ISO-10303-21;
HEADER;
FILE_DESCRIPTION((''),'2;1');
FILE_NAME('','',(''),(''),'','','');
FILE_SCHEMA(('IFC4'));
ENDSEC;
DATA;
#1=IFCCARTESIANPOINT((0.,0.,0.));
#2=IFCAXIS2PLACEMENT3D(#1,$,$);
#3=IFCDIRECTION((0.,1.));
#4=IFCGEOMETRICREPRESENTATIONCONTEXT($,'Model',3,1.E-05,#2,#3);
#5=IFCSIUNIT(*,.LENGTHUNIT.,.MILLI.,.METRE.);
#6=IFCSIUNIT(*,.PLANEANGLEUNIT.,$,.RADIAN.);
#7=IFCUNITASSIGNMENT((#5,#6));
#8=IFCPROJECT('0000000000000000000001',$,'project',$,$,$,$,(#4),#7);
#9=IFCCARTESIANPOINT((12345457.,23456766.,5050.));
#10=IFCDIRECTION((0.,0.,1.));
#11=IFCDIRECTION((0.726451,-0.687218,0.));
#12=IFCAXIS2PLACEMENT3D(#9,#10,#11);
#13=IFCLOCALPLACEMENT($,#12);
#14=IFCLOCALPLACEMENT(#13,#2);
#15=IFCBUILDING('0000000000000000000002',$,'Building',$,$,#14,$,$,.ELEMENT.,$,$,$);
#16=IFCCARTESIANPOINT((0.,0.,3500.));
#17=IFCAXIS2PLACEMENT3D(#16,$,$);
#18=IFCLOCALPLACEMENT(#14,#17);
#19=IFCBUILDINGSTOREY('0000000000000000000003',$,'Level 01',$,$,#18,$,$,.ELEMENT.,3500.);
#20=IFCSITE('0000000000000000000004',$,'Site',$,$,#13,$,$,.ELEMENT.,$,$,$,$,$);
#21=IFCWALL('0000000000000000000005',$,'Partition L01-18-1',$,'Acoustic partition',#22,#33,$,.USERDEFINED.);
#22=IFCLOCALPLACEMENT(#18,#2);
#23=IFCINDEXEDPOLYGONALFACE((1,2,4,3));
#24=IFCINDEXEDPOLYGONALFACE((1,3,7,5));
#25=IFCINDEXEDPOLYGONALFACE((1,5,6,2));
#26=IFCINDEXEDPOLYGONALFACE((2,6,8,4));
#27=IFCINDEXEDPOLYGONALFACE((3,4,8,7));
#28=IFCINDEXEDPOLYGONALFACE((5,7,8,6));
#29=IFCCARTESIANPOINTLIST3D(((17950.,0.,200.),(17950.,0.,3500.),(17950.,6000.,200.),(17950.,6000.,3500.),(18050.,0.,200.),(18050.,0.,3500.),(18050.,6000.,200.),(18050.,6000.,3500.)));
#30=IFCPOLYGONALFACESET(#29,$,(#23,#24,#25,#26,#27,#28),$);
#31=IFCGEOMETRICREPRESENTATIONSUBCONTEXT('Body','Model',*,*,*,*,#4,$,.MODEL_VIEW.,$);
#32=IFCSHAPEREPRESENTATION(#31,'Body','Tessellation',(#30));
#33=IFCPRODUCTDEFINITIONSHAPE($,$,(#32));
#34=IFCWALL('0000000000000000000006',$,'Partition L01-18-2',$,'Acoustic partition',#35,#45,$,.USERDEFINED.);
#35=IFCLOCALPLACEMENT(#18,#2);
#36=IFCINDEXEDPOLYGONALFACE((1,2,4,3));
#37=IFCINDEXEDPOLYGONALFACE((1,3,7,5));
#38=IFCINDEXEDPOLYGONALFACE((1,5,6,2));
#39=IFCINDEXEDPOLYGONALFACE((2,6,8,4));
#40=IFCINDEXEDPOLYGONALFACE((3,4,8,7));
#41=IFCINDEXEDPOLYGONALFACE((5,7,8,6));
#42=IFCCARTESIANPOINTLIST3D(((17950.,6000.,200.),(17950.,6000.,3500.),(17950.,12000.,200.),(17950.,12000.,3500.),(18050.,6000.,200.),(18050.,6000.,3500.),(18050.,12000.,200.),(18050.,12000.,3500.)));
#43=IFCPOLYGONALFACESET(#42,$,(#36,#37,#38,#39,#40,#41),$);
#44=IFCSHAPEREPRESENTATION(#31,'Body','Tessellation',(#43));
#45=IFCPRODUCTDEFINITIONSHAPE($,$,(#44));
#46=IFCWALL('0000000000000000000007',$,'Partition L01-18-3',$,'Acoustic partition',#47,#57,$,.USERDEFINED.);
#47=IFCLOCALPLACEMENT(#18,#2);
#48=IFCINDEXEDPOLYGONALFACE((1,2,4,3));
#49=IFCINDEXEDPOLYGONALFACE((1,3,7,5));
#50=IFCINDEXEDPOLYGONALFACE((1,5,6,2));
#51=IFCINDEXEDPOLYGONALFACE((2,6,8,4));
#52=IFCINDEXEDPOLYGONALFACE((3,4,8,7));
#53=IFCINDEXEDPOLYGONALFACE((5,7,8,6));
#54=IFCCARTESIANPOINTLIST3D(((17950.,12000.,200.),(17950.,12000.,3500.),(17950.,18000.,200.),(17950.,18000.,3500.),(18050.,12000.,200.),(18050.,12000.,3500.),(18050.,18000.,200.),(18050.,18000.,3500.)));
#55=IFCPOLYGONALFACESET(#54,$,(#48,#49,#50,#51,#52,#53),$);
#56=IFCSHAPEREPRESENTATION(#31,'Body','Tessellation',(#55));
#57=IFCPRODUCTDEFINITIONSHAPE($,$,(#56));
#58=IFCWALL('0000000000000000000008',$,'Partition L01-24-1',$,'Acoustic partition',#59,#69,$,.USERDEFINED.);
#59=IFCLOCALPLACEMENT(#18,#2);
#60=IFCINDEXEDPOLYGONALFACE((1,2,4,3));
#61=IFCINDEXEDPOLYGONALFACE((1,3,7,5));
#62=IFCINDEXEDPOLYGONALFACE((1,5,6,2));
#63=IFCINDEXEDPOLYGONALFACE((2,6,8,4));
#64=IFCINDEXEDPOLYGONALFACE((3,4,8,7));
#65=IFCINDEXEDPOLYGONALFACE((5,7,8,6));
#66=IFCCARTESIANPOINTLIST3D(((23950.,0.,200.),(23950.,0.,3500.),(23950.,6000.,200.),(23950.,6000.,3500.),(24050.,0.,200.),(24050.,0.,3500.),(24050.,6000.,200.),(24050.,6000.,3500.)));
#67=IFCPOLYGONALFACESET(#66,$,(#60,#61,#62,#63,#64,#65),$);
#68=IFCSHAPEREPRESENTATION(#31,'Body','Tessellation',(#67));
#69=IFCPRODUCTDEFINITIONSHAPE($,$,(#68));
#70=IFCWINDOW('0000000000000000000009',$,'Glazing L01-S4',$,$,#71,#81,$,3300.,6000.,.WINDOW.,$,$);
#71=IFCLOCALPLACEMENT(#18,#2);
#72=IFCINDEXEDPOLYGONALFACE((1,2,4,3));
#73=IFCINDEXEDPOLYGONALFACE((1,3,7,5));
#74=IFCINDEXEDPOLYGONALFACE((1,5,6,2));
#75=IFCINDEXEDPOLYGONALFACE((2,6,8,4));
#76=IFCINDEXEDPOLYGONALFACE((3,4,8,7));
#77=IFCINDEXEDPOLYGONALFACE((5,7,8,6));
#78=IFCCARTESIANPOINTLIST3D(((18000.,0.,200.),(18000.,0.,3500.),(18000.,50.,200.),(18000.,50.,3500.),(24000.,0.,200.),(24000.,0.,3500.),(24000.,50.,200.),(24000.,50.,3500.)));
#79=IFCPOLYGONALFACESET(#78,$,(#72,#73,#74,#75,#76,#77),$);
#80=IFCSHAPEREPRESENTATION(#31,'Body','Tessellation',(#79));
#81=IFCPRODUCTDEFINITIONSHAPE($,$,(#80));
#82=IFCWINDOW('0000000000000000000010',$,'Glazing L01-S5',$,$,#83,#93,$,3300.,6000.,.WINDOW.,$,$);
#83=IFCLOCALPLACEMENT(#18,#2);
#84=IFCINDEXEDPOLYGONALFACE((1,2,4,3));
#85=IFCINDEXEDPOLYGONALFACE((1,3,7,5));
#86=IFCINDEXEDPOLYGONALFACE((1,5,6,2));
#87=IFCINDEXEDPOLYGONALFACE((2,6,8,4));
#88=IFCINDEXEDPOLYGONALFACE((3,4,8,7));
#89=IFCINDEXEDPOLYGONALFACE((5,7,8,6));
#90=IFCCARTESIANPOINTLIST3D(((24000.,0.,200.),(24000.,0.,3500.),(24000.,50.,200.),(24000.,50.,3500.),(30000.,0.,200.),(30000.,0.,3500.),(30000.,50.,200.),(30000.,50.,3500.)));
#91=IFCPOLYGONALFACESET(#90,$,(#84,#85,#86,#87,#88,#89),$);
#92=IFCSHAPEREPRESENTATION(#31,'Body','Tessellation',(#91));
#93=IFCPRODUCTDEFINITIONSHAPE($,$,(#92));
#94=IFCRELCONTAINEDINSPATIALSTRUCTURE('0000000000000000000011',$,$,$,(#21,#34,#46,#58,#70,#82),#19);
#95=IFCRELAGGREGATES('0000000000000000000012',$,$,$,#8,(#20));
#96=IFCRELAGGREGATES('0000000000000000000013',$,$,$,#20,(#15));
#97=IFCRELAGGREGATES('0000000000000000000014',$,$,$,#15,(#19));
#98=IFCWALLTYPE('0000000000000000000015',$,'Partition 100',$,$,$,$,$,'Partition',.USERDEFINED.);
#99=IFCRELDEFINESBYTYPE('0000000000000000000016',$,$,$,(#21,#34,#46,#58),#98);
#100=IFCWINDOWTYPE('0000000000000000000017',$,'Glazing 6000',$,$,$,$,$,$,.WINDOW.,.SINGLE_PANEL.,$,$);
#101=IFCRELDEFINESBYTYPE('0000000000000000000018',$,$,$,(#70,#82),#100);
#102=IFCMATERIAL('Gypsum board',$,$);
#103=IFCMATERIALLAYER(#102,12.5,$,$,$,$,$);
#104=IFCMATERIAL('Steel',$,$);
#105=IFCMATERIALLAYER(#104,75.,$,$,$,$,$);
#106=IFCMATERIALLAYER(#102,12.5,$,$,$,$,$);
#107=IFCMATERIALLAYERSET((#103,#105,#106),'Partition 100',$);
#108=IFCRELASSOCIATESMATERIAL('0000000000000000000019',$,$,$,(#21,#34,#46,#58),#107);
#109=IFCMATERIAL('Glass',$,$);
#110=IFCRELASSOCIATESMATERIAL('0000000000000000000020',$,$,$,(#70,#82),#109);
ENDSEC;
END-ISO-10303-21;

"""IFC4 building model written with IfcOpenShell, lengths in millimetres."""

from ifc_helpers import new_model, si_unit, direction, frame, origin, place, context, subcontext, project, spatial, rectangle, extrude, material, layer, layer_set, layer_usage, type_object, element, save


model = new_model("IFC4")

# Units and contexts
model_context = context("Model", 3, precision=1e-05, world=origin(), true_north=direction((0.0, 1.0)))
body_context = subcontext(model_context, "Body", "Model", "MODEL_VIEW")
ifc_project = project(units=[si_unit("LENGTHUNIT", "METRE", prefix="MILLI"), si_unit("PLANEANGLEUNIT", "RADIAN")], contexts=[model_context])

# Site, building, storey
site_placement = place(None, frame((12345457.0, 23456766.0, 5050.0), z_axis=(0.0, 0.0, 1.0), x_axis=(0.726451, -0.687218, 0.0)))
site = spatial("IfcSite", under=ifc_project, at=site_placement, Name="Site", CompositionType="ELEMENT")
building_placement = place(site_placement, origin())
building = spatial("IfcBuilding", under=site, at=building_placement, Name="Building", CompositionType="ELEMENT")
storey_placement = place(building_placement, frame((0.0, 0.0, 3500.0)))
storey = spatial("IfcBuildingStorey", under=building, at=storey_placement, Name="Level 01", CompositionType="ELEMENT", Elevation=3500.0)

# Shared definitions
ifc_material_1 = material(Name="Steel")

# Walls
ifc_material_2 = material(Name="Gypsum board")
ifc_layer_1 = layer(ifc_material_2, 12.5)
ifc_layer_2 = layer(ifc_material_1, 75.0)
ifc_layer_3 = layer(ifc_material_2, 12.5)
ifc_layer_set = layer_set([ifc_layer_1, ifc_layer_2, ifc_layer_3], Name="Partition 100")
ifc_layer_usage = layer_usage(ifc_layer_set, "AXIS2", "POSITIVE", 0.0)
wall_type = type_object("IfcWallType", Name="Partition 100", ElementType="Partition", PredefinedType="USERDEFINED")
for number, where, name in (
    (1, (17950.0, 0.0, 200.0), "Partition L01-18-1"),
    (2, (17950.0, 6000.0, 200.0), "Partition L01-18-2"),
    (3, (17950.0, 12000.0, 200.0), "Partition L01-18-3"),
    (4, (23950.0, 0.0, 200.0), "Partition L01-24-1"),
):
    element("IfcWall", number, at=place(storey_placement, frame(where)), inside=storey, type_object=wall_type, material=ifc_layer_usage, Name=name, ObjectType="Acoustic partition", PredefinedType="USERDEFINED", context=body_context, shape_type="SweptSolid", body=[
        extrude(rectangle(XDim=100.0, YDim=6000.0), frame((50.0, 3000.0, 0.0)), (0.0, 0.0, 1.0), 3300.0),
    ])

# Windows
ifc_material_3 = material(Name="Glass")
window_type = type_object("IfcWindowType", Name="Glazing 6000", PartitioningType="SINGLE_PANEL", PredefinedType="WINDOW")
for number, where, name in (
    (5, (18000.0, 0.0, 200.0), "Glazing L01-S4"),
    (6, (24000.0, 0.0, 200.0), "Glazing L01-S5"),
):
    element("IfcWindow", number, at=place(storey_placement, frame(where)), inside=storey, type_object=window_type, material=ifc_material_3, Name=name, OverallHeight=3300.0, OverallWidth=6000.0, PredefinedType="WINDOW", context=body_context, shape_type="SweptSolid", body=[
        extrude(rectangle(XDim=6000.0, YDim=50.0), frame((3000.0, 25.0, 0.0)), (0.0, 0.0, 1.0), 3300.0),
    ])

save(model, "model.ifc")
